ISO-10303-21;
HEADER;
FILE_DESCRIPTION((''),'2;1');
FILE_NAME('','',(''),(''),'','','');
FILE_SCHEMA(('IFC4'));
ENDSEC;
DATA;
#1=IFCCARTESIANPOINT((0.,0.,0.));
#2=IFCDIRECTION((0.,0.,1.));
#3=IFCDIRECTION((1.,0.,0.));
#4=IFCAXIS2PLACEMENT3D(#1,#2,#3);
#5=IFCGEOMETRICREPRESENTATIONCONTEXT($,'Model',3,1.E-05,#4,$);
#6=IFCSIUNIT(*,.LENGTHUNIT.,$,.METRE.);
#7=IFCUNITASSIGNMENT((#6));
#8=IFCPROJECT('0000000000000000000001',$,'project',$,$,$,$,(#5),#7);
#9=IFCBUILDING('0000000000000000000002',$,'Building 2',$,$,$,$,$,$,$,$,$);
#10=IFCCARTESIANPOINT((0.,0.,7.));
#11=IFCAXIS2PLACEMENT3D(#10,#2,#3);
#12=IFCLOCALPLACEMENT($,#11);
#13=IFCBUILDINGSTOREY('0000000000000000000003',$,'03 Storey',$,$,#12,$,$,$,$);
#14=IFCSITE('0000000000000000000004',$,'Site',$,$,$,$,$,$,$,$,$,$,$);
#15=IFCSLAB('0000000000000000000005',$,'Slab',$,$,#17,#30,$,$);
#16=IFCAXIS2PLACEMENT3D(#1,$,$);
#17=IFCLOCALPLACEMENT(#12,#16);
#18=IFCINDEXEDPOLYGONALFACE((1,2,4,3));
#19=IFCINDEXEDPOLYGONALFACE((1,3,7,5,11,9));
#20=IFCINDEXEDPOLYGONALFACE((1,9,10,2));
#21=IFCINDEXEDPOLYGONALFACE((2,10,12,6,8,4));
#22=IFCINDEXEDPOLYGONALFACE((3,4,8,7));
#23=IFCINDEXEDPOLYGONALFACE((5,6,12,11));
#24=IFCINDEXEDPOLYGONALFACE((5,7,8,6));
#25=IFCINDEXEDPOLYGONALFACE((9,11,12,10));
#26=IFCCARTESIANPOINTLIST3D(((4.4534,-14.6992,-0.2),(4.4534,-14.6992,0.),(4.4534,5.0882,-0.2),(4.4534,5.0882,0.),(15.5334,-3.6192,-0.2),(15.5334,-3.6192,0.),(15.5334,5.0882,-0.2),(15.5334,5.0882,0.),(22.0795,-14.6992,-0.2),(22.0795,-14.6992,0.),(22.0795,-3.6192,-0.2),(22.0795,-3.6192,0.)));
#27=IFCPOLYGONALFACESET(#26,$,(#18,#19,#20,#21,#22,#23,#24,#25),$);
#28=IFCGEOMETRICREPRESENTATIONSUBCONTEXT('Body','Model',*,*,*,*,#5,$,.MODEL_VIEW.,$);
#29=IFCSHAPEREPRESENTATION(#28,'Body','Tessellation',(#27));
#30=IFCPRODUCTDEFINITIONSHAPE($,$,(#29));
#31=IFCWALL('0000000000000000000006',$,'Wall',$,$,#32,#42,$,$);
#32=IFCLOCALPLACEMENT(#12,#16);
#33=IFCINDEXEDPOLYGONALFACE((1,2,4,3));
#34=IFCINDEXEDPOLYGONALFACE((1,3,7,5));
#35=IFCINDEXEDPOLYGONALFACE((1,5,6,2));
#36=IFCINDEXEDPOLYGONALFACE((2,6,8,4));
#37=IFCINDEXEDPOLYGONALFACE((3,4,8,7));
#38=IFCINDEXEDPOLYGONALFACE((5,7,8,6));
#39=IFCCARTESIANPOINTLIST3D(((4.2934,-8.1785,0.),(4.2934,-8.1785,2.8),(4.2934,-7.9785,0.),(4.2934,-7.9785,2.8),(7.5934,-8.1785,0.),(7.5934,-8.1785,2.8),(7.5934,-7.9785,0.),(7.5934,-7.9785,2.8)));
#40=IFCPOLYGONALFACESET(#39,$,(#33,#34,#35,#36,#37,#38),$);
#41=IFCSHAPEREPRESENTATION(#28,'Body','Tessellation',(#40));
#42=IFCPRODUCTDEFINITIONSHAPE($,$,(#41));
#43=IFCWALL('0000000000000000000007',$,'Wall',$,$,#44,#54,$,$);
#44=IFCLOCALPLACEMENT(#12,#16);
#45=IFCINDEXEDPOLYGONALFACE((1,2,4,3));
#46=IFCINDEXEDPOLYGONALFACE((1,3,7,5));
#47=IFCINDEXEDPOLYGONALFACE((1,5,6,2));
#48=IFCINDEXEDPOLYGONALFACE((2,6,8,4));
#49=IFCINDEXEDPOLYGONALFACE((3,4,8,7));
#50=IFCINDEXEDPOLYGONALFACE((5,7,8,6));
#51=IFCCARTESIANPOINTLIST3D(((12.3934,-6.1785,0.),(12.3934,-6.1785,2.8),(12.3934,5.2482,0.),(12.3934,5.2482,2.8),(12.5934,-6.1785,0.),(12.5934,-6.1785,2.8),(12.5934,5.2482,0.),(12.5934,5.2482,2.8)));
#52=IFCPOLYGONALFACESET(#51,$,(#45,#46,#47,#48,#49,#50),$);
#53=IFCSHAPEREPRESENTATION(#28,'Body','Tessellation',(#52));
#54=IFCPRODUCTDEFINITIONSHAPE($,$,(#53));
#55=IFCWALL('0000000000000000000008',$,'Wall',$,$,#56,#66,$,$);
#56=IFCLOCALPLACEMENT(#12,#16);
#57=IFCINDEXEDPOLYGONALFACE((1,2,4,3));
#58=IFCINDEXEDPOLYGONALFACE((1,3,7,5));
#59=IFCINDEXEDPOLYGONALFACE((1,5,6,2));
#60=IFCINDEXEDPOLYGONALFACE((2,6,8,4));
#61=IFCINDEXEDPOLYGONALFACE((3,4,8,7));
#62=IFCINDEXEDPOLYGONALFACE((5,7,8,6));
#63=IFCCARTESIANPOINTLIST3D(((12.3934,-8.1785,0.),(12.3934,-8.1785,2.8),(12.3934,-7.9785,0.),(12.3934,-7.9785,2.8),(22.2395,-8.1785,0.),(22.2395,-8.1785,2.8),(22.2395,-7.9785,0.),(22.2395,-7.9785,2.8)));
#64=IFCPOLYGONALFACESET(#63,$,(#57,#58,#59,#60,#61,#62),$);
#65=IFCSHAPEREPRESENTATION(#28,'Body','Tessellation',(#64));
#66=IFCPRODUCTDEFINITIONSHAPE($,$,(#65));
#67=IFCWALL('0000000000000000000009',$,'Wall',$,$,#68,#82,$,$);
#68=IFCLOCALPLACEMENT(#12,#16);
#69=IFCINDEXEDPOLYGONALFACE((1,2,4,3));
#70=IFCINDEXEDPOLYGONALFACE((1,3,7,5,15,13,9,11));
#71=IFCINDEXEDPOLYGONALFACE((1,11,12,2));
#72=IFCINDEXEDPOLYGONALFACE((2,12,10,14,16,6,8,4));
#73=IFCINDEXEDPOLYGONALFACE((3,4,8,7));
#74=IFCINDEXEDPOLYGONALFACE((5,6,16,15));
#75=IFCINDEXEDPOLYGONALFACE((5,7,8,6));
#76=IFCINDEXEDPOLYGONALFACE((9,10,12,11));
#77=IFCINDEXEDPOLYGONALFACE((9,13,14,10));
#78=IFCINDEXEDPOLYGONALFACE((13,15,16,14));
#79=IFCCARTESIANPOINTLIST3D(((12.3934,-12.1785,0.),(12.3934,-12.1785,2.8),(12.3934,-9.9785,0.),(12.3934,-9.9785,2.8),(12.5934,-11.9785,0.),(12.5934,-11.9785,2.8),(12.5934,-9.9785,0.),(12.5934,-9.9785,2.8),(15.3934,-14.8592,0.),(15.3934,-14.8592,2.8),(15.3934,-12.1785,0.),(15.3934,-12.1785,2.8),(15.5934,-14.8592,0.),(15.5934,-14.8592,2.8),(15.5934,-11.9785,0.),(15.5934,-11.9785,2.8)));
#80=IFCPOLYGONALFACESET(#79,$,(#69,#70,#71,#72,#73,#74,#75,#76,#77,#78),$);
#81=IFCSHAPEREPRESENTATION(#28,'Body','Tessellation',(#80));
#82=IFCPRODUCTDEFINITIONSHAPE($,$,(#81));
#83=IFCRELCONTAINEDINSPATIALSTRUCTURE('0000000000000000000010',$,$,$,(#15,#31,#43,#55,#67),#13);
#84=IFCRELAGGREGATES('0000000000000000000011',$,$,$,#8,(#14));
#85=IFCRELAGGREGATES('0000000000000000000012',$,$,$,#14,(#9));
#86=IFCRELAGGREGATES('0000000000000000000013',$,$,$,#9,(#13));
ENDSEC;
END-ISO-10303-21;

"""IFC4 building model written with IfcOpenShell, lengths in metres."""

from ifc_helpers import new_model, si_unit, frame, origin_with_axes, place, context, subcontext, project, spatial, line, indexed_curve, outline, extrude, element, save


model = new_model("IFC4")

# Units and contexts
model_context = context("Model", 3, precision=1e-05, world=origin_with_axes())
body_context = subcontext(model_context, "Body", "Model", "MODEL_VIEW")
ifc_project = project(units=[si_unit("LENGTHUNIT", "METRE")], contexts=[model_context])

# Site, building, storey
site = spatial("IfcSite", under=ifc_project, Name="Site")
building = spatial("IfcBuilding", under=site, Name="Building 2")
storey_placement = place(None, frame((0.0, 0.0, 7.0), z_axis=(0.0, 0.0, 1.0), x_axis=(1.0, 0.0, 0.0)))
storey = spatial("IfcBuildingStorey", under=building, at=storey_placement, Name="03 Storey")

# Slab
slab_placement = place(storey_placement, origin_with_axes())
element("IfcSlab", 1, at=slab_placement, inside=storey, Name="Slab", context=body_context, shape_type="SweptSolid", body=[
    extrude(outline(indexed_curve([(22.0795, -3.6192), (15.5334, -3.6192), (15.5334, 5.0882), (4.4534, 5.0882), (4.4534, -14.6992), (22.0795, -14.6992)], segments=[line(1, 2), line(2, 3), line(3, 4), line(4, 5), line(5, 6)])), origin_with_axes(), (0.0, 0.0, -1.0), 0.2),
])

# Walls
wall_1_placement = place(storey_placement, origin_with_axes())
element("IfcWall", 2, at=wall_1_placement, inside=storey, Name="Wall", context=body_context, shape_type="SweptSolid", body=[
    extrude(outline(indexed_curve([(7.5934, -7.9785), (4.2934, -7.9785), (4.2934, -8.1785), (7.5934, -8.1785)], segments=[line(1, 2), line(2, 3), line(3, 4)])), origin_with_axes(), (0.0, 0.0, 1.0), 2.8),
])
wall_2_placement = place(storey_placement, origin_with_axes())
element("IfcWall", 3, at=wall_2_placement, inside=storey, Name="Wall", context=body_context, shape_type="SweptSolid", body=[
    extrude(outline(indexed_curve([(12.5934, 5.2482), (12.3934, 5.2482), (12.3934, -6.1785), (12.5934, -6.1785)], segments=[line(1, 2), line(2, 3), line(3, 4)])), origin_with_axes(), (0.0, 0.0, 1.0), 2.8),
])
wall_3_placement = place(storey_placement, origin_with_axes())
element("IfcWall", 4, at=wall_3_placement, inside=storey, Name="Wall", context=body_context, shape_type="SweptSolid", body=[
    extrude(outline(indexed_curve([(22.2395, -7.9785), (12.3934, -7.9785), (12.3934, -8.1785), (22.2395, -8.1785)], segments=[line(1, 2), line(2, 3), line(3, 4)])), origin_with_axes(), (0.0, 0.0, 1.0), 2.8),
])
wall_4_placement = place(storey_placement, origin_with_axes())
element("IfcWall", 5, at=wall_4_placement, inside=storey, Name="Wall", context=body_context, shape_type="SweptSolid", body=[
    extrude(outline(indexed_curve([(15.5934, -11.9785), (12.5934, -11.9785), (12.5934, -9.9785), (12.3934, -9.9785), (12.3934, -12.1785), (15.3934, -12.1785), (15.3934, -14.8592), (15.5934, -14.8592)], segments=[line(1, 2), line(2, 3), line(3, 4), line(4, 5), line(5, 6), line(6, 7), line(7, 8)])), origin_with_axes(), (0.0, 0.0, 1.0), 2.8),
])

save(model, "model.ifc")
